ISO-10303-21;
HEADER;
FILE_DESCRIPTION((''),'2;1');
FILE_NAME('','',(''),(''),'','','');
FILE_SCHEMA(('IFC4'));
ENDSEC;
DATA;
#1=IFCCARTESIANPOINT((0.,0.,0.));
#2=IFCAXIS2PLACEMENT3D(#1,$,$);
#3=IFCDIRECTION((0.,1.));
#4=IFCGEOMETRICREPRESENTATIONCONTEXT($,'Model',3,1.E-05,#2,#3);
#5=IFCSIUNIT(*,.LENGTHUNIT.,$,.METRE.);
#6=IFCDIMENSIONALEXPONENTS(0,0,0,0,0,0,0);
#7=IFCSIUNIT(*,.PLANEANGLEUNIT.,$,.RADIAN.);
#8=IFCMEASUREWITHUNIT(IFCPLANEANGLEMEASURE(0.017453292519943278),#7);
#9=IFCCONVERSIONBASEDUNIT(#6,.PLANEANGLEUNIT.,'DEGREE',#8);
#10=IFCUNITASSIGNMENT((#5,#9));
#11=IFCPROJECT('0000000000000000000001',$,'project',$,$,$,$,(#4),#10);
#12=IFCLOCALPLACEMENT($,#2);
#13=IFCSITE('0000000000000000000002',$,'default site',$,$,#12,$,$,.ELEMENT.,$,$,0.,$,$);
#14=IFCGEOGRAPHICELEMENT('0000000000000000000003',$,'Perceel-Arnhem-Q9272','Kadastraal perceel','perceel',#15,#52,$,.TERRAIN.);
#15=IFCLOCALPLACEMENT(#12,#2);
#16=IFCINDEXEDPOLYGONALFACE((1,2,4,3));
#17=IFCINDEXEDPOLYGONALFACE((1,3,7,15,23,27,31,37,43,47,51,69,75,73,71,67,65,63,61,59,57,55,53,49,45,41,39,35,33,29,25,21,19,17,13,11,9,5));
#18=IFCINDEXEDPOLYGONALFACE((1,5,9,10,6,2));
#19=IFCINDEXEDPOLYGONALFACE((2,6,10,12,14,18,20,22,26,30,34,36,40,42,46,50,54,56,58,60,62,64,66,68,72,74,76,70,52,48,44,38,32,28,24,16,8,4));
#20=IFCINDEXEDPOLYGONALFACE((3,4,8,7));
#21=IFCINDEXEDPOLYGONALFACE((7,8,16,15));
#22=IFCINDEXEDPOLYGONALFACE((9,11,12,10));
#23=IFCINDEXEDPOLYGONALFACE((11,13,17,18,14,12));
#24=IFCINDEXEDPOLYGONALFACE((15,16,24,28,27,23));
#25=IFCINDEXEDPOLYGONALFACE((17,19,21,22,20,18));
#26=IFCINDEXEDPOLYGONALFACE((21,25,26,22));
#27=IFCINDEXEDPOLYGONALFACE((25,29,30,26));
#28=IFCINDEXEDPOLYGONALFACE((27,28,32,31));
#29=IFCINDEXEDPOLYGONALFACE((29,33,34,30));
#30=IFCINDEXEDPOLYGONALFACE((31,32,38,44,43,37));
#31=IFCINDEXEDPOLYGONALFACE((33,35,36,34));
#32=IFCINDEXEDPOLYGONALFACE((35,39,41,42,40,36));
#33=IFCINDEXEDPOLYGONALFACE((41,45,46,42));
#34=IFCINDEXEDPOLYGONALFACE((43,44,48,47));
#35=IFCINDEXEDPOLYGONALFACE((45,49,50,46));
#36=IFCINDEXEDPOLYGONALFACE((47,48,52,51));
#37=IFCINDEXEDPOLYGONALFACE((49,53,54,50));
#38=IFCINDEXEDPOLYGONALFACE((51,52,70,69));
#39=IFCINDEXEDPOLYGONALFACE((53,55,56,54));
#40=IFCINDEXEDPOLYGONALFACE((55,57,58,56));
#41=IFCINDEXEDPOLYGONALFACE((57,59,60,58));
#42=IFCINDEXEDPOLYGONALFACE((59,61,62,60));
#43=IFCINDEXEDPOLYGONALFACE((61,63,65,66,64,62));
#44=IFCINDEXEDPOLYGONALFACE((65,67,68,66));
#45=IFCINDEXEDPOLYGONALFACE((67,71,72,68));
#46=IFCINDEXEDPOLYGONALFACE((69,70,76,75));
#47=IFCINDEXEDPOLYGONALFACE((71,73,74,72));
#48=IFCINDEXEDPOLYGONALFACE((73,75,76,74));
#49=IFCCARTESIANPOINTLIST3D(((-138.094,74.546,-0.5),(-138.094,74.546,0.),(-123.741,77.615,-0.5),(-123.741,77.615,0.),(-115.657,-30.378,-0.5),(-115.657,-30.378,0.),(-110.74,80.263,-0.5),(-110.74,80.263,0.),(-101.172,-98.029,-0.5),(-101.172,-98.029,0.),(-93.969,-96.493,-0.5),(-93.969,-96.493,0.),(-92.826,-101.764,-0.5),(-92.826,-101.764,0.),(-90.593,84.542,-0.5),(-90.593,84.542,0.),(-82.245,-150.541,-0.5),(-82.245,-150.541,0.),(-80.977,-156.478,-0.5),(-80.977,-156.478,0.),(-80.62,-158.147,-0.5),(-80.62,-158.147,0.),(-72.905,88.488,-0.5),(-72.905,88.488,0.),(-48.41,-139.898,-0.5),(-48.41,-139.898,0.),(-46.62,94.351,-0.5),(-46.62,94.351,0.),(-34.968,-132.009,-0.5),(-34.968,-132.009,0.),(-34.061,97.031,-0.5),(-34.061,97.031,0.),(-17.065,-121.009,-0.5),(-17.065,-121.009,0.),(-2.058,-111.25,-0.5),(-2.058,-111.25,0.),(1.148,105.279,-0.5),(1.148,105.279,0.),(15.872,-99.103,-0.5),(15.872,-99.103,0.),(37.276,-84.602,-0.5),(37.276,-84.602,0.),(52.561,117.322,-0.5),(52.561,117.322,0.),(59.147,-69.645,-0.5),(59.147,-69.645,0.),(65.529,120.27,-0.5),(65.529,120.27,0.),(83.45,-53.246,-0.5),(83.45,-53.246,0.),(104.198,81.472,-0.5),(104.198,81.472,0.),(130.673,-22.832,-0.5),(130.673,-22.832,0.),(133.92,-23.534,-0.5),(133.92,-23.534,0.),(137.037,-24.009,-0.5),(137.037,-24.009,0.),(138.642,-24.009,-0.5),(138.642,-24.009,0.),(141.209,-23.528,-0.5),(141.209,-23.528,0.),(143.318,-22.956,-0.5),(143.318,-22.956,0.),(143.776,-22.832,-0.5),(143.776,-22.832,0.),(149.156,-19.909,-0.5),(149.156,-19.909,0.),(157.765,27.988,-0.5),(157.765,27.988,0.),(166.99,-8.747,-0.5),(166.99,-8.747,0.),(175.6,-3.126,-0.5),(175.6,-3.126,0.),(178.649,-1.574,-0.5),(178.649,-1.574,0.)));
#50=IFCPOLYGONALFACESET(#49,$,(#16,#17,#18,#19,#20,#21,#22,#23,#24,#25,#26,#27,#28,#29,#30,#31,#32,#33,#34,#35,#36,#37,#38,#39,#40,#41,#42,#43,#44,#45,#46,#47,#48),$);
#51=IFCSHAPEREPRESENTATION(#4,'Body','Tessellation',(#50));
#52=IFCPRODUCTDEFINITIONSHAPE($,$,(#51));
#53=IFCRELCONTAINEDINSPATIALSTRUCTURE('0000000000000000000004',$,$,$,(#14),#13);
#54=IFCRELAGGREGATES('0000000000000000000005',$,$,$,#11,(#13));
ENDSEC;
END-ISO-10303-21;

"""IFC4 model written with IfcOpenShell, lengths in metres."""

from ifc_helpers import new_model, entity, si_unit, converted_unit, direction, frame, origin, place, context, project, spatial, indexed_curve, outline, extrude, element, save


model = new_model("IFC4")

# Units and contexts
model_context = context("Model", 3, precision=1e-05, world=origin(), true_north=direction((0.0, 1.0)))
ifc_project = project(units=[si_unit("LENGTHUNIT", "METRE"), converted_unit("PLANEANGLEUNIT", "DEGREE", entity("IfcPlaneAngleMeasure", 0.017453292519943278), si_unit("PLANEANGLEUNIT", "RADIAN"), dimensions=[0, 0, 0, 0, 0, 0, 0])], contexts=[model_context])

# Site
placement = place(None, origin())
site = spatial("IfcSite", under=ifc_project, at=placement, Name="default site", CompositionType="ELEMENT", RefElevation=0.0)

# Geographic element
element("IfcGeographicElement", 1, at=placement, inside=site, Name="Perceel-Arnhem-Q9272", Description="Kadastraal perceel", ObjectType="perceel", PredefinedType="TERRAIN", context=model_context, shape_type="SweptSolid", body=[
    extrude(outline(indexed_curve([(143.318, -22.956), (143.776, -22.832), (149.156, -19.909), (166.99, -8.747), (175.6, -3.126), (178.649, -1.574), (157.765, 27.988), (104.198, 81.472), (65.529, 120.27), (52.561, 117.322), (1.148, 105.279), (-34.061, 97.031), (-46.62, 94.351), (-72.905, 88.488), (-90.593, 84.542), (-110.74, 80.263), (-123.741, 77.615), (-138.094, 74.546), (-115.657, -30.378), (-101.172, -98.029), (-93.969, -96.493), (-92.826, -101.764), (-82.245, -150.541), (-80.977, -156.478), (-80.62, -158.147), (-48.41, -139.898), (-34.968, -132.009), (-17.065, -121.009), (-2.058, -111.25), (15.872, -99.103), (37.276, -84.602), (59.147, -69.645), (83.45, -53.246), (130.673, -22.832), (133.92, -23.534), (137.037, -24.009), (138.642, -24.009), (141.209, -23.528), (143.318, -22.956)], self_intersect=False)), frame((0.0, 0.0, -0.5)), (0.0, 0.0, 1.0), 0.5),
])

save(model, "model.ifc")
